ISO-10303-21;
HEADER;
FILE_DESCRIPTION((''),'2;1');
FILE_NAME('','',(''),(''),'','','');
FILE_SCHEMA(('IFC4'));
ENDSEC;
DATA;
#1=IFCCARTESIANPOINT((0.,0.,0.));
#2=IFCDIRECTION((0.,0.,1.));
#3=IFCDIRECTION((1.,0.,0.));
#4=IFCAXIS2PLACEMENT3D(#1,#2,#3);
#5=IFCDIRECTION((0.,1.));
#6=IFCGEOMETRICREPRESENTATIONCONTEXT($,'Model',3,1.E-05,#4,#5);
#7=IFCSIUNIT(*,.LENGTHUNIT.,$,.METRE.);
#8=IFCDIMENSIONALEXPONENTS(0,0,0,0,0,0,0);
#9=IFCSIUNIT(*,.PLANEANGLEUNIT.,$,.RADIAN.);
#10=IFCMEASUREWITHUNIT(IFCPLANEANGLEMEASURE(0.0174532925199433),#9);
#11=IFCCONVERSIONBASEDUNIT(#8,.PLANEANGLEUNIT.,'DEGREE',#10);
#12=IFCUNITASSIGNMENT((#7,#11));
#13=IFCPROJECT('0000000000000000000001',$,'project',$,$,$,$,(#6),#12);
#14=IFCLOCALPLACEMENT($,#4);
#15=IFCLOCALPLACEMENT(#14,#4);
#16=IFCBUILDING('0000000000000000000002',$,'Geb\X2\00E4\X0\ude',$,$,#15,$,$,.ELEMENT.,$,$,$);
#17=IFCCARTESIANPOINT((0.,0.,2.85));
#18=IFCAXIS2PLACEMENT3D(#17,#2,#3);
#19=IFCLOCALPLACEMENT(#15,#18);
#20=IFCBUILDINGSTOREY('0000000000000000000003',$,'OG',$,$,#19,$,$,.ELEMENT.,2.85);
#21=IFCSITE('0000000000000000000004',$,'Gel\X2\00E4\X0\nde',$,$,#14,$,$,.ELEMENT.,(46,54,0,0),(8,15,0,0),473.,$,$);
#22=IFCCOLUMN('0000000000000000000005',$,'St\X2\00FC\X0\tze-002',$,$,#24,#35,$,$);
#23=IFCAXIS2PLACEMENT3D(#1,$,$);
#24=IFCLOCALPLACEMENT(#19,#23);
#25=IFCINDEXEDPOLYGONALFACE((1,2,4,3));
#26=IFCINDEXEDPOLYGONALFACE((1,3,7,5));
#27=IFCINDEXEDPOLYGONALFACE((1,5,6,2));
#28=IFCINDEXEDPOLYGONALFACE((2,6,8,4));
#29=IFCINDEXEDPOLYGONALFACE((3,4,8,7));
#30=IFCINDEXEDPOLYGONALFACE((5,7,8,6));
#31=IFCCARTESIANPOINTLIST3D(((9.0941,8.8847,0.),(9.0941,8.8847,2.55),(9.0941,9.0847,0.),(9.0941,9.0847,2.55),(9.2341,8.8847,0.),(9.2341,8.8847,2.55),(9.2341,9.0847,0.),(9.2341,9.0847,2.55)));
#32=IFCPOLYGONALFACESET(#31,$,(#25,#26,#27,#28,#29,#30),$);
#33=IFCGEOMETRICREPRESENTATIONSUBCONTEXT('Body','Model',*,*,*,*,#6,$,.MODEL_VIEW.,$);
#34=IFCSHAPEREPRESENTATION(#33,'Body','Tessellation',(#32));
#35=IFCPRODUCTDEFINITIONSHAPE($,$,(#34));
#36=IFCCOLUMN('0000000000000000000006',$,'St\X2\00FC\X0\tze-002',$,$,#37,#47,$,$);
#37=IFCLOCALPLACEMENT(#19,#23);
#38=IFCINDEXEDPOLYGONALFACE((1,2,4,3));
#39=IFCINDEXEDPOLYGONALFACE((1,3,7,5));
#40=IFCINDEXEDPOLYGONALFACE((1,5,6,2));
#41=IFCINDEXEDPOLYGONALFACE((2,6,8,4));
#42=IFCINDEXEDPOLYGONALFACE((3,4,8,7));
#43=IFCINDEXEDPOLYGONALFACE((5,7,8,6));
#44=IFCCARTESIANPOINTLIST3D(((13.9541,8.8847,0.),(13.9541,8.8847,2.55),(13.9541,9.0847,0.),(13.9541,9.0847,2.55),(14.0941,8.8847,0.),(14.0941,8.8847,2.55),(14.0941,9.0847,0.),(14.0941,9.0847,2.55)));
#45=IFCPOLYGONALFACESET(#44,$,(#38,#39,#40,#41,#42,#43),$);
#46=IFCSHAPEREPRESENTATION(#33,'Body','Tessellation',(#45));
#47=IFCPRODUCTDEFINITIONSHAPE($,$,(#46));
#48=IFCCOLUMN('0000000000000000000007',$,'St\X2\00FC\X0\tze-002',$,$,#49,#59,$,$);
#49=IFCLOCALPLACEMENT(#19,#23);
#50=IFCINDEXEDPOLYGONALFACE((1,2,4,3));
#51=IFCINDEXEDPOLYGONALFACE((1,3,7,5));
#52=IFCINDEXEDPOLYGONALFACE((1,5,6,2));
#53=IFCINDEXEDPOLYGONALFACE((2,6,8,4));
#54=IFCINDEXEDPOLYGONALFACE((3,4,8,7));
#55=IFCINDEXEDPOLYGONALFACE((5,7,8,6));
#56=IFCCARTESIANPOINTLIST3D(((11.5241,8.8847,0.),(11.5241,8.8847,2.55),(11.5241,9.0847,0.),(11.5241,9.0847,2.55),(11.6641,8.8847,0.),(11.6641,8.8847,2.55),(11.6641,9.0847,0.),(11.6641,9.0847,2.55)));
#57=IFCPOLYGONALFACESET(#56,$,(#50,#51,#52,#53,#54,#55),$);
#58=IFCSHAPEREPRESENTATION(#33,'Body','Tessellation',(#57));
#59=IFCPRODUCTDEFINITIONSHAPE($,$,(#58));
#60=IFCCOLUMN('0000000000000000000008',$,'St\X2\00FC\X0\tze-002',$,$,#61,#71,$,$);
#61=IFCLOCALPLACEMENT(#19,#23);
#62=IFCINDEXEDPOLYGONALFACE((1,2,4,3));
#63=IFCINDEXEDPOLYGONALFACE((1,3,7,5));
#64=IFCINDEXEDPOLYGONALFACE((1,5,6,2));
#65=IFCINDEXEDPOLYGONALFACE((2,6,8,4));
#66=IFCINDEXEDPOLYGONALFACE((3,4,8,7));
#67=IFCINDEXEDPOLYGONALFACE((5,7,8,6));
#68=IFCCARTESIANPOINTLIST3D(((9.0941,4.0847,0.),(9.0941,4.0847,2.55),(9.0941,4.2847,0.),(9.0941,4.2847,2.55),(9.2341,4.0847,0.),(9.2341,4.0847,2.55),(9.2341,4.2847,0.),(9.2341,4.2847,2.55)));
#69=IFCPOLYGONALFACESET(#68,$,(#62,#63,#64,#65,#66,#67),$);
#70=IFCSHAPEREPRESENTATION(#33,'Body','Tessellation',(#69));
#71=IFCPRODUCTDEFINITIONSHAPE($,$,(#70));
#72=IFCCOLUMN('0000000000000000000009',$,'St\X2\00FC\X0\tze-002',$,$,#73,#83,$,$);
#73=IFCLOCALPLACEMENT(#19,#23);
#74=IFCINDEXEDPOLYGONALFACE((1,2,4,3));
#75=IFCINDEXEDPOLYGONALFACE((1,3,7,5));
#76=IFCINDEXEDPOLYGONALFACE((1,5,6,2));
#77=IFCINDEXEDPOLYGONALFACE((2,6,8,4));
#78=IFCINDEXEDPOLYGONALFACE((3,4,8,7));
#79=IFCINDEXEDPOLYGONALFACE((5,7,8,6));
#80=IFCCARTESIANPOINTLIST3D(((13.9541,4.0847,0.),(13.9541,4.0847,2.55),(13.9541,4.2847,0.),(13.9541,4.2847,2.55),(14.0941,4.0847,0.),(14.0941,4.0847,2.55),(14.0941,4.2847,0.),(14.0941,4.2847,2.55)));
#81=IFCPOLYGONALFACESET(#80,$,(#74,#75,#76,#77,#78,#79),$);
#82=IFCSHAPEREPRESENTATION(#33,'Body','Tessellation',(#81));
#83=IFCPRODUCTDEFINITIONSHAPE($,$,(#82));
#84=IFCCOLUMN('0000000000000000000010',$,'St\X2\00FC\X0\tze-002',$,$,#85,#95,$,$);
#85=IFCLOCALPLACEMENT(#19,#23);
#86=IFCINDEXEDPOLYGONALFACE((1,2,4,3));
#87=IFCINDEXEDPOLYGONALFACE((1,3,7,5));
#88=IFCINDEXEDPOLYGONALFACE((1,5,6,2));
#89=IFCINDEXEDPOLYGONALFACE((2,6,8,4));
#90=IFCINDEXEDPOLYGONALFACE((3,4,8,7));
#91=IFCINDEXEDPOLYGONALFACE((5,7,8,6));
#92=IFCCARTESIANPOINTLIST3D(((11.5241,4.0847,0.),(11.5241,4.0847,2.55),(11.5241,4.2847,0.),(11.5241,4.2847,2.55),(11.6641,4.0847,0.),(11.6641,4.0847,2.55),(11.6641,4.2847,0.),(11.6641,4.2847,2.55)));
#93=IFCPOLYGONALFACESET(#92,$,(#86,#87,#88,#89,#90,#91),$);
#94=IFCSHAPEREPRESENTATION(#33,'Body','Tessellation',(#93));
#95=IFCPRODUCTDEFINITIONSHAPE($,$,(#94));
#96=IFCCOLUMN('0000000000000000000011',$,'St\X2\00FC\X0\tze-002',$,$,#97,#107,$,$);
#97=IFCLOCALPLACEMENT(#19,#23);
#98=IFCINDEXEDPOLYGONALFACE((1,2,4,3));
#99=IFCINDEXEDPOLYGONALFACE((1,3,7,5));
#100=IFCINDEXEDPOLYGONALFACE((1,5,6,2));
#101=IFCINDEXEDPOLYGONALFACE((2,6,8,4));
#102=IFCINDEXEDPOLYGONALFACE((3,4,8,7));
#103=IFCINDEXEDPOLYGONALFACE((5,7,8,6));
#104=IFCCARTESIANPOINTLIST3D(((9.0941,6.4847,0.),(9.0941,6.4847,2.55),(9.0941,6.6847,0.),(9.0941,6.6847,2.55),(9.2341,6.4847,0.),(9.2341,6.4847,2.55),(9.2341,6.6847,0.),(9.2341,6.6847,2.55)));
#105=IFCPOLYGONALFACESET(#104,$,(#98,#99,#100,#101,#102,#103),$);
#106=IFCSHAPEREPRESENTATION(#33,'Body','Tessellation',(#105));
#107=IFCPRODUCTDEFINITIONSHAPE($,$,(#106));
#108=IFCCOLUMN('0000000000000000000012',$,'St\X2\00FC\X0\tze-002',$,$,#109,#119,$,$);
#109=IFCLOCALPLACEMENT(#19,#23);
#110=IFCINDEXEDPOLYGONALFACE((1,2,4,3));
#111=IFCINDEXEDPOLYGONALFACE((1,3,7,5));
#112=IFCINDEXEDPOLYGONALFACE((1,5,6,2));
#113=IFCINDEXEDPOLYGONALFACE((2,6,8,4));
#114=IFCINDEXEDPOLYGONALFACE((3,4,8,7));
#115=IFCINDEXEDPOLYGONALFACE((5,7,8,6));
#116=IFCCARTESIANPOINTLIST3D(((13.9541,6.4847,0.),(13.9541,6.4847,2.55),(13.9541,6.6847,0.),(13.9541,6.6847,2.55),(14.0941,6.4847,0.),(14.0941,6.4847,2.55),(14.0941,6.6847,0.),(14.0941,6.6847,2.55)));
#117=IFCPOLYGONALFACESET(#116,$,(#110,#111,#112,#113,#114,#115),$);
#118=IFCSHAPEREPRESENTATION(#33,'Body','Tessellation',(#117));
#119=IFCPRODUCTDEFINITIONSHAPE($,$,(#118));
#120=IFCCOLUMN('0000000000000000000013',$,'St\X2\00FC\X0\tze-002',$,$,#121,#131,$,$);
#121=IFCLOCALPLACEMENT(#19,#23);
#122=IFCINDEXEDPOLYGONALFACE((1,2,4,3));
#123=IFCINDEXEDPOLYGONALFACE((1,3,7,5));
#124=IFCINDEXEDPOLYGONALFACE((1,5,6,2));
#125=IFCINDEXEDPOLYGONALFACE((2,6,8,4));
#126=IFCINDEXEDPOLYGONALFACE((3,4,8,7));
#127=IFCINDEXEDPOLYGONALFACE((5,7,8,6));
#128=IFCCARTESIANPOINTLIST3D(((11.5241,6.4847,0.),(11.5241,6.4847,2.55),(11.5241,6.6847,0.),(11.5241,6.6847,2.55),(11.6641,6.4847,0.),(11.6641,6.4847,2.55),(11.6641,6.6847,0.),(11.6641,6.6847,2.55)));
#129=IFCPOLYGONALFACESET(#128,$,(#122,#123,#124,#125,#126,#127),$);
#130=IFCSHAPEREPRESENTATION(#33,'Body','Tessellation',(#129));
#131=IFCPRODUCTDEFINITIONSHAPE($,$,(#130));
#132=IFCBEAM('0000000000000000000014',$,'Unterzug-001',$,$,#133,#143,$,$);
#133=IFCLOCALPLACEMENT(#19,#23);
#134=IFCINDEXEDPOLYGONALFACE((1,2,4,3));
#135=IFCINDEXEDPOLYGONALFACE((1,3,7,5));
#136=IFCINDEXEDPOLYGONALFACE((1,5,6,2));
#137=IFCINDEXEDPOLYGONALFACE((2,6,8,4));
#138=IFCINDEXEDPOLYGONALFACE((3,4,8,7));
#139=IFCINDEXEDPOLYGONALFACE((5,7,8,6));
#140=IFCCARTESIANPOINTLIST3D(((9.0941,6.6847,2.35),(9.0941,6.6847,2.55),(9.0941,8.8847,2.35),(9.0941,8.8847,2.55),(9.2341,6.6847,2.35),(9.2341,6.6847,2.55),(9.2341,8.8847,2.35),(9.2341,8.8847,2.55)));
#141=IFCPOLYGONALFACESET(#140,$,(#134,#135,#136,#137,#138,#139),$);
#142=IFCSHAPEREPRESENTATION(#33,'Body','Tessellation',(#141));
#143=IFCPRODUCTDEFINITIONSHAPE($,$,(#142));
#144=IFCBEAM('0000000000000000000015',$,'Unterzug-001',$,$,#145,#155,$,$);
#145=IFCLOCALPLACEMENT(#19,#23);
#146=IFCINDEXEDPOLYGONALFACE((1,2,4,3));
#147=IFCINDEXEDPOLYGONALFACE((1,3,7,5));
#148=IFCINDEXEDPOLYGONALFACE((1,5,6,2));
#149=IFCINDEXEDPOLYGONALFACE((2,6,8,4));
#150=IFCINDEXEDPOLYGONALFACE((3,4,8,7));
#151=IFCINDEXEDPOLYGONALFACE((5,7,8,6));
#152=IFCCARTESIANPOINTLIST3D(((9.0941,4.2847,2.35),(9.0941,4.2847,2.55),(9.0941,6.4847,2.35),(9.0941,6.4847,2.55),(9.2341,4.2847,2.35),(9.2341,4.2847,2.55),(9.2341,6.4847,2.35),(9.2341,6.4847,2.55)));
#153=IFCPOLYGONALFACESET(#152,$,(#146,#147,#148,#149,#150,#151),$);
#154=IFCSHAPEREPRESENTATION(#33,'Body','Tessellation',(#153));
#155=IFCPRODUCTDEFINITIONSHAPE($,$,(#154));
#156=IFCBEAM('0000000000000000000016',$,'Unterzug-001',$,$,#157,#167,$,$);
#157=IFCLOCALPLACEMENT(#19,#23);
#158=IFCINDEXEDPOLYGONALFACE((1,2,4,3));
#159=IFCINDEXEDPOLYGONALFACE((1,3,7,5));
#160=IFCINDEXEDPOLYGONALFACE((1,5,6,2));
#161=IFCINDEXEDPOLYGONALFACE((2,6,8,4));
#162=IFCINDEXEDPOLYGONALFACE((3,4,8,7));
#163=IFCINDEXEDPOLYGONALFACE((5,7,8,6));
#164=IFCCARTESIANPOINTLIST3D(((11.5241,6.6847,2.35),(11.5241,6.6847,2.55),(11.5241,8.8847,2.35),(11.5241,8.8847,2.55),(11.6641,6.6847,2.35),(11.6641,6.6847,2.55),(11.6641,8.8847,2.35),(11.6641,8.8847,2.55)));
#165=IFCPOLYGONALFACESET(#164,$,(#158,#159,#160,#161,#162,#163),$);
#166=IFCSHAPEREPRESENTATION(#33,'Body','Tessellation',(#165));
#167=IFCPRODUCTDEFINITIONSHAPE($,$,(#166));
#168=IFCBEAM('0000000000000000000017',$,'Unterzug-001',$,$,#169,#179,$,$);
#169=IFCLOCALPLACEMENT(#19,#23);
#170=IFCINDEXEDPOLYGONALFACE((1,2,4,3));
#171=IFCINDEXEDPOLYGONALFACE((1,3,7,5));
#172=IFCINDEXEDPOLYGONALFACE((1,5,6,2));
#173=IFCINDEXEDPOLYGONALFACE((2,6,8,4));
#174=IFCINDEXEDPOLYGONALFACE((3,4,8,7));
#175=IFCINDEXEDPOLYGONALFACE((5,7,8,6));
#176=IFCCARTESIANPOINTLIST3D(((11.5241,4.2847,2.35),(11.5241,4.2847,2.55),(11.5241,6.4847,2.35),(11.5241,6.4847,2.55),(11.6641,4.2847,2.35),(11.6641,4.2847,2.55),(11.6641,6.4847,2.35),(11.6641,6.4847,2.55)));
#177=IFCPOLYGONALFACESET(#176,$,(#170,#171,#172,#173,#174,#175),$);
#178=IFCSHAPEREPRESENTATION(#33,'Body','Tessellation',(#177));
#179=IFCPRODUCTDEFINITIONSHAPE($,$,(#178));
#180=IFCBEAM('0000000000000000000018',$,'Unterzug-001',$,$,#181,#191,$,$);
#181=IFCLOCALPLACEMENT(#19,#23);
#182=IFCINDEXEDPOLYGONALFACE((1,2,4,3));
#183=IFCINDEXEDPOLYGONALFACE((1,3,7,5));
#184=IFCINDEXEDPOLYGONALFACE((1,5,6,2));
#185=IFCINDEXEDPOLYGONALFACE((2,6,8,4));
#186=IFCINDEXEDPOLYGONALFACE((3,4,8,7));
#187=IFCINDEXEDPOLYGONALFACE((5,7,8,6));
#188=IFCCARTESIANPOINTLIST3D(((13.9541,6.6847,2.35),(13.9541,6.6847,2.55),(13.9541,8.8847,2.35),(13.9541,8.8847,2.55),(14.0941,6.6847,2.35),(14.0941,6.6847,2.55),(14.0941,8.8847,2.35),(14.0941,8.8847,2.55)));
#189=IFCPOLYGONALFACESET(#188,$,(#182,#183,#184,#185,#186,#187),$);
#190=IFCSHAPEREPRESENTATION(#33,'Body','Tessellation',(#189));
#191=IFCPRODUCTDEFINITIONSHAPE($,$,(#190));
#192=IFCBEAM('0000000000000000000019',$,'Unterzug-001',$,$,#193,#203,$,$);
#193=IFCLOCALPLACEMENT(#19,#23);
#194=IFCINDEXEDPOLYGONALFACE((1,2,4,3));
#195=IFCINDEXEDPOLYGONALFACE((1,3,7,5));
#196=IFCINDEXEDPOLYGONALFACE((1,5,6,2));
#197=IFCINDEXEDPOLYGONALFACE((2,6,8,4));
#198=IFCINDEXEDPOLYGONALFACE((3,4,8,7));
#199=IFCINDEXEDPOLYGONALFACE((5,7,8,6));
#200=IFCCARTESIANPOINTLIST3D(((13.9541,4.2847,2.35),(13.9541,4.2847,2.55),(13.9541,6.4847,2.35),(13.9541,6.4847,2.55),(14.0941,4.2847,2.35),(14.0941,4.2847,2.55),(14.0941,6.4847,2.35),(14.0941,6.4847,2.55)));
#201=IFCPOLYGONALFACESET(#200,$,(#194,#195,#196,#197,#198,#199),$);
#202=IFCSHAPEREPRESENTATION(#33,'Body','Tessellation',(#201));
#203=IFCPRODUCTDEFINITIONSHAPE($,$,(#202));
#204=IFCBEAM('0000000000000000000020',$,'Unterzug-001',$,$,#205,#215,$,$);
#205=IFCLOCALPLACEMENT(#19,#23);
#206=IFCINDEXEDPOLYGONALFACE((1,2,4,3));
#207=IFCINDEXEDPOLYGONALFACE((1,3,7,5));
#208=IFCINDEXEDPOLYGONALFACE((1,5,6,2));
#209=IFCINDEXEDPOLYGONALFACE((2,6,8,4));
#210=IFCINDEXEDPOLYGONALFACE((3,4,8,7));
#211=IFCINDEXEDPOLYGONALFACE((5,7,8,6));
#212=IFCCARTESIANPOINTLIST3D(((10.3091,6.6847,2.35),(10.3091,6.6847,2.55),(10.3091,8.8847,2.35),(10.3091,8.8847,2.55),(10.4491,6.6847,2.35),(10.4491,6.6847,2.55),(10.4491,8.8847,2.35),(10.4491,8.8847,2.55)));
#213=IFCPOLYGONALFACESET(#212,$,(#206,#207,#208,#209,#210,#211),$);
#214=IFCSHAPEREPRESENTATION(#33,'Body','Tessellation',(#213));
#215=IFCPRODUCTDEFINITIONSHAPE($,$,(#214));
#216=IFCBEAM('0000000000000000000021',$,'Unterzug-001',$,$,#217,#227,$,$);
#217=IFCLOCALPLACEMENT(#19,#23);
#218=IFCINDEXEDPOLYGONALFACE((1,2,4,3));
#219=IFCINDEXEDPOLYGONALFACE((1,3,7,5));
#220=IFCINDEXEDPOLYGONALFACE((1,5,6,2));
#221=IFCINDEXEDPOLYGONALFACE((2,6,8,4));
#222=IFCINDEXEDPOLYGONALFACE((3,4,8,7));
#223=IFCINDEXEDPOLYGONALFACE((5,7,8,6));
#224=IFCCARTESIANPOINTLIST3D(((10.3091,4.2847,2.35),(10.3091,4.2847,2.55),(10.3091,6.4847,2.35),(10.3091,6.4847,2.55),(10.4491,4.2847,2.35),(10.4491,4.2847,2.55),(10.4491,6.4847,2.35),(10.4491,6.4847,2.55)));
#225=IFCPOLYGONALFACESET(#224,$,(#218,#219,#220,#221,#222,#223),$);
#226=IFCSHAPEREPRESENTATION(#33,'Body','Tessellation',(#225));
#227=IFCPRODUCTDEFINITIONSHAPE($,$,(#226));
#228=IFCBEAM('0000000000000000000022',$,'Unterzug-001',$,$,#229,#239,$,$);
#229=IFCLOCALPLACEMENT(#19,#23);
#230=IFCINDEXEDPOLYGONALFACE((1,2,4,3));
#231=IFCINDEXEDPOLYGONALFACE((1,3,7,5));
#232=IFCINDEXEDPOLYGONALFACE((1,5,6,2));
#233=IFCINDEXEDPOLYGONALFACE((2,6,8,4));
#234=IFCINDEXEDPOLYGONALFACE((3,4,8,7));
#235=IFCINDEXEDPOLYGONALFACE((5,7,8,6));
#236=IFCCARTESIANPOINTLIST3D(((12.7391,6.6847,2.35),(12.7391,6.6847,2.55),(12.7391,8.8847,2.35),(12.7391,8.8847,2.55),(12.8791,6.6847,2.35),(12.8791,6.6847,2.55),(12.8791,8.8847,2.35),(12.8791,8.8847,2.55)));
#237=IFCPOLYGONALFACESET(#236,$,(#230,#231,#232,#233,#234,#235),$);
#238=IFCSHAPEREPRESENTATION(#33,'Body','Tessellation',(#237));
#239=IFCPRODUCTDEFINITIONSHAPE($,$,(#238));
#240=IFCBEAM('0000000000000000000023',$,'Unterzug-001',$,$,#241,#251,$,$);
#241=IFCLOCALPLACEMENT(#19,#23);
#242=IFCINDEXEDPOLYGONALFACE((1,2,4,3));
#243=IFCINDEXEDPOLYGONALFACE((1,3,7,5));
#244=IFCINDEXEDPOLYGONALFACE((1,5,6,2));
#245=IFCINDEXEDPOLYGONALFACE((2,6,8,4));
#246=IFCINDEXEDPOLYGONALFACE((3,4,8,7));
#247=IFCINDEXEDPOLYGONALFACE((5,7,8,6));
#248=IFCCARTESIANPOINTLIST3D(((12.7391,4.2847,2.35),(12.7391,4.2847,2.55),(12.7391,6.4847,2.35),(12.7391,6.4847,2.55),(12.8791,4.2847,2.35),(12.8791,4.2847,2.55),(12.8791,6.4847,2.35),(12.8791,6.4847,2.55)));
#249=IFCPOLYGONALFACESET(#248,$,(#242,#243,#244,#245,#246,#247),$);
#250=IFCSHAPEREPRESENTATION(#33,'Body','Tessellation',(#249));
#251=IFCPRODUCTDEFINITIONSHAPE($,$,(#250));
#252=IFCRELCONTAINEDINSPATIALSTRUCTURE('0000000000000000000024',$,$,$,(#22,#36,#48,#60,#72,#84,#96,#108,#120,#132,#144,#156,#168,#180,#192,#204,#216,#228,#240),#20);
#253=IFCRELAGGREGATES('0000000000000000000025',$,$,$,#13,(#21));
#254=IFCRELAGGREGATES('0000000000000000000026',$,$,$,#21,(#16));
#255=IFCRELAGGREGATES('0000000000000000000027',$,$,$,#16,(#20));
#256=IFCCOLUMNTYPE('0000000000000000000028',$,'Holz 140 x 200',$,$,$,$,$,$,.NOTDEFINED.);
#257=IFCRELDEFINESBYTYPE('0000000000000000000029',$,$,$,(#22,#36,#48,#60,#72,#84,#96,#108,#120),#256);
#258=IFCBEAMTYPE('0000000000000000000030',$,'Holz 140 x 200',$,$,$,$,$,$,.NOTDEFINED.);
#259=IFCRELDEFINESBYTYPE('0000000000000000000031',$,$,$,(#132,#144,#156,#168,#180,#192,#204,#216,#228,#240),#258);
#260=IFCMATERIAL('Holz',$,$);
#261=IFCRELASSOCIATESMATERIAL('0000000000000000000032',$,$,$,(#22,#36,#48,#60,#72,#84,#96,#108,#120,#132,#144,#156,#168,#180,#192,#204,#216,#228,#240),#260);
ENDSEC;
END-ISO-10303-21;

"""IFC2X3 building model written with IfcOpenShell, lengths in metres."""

from ifc_helpers import new_model, entity, si_unit, converted_unit, direction, frame, frame_2d, origin_with_axes, origin_2d_with_axis, place, context, subcontext, project, spatial, rectangle, extrude, material, type_object, element, save


model = new_model("IFC2X3")

# Units and contexts
model_context = context("Model", 3, precision=1e-05, world=origin_with_axes(), true_north=direction((0.0, 1.0)))
body_context = subcontext(model_context, "Body", "Model", "MODEL_VIEW")
ifc_project = project(units=[si_unit("LENGTHUNIT", "METRE"), converted_unit("PLANEANGLEUNIT", "DEGREE", entity("IfcPlaneAngleMeasure", 0.0174532925199433), si_unit("PLANEANGLEUNIT", "RADIAN"), dimensions=[0, 0, 0, 0, 0, 0, 0])], contexts=[model_context])

# Site, building, storey
site_placement = place(None, origin_with_axes())
site = spatial("IfcSite", under=ifc_project, at=site_placement, Name="Gelände", CompositionType="ELEMENT", RefLatitude=(46, 54, 0, 0), RefLongitude=(8, 15, 0, 0), RefElevation=473.0)
building_placement = place(site_placement, origin_with_axes())
building = spatial("IfcBuilding", under=site, at=building_placement, Name="Gebäude", CompositionType="ELEMENT")
storey_placement = place(building_placement, frame((0.0, 0.0, 2.85), z_axis=(0.0, 0.0, 1.0), x_axis=(1.0, 0.0, 0.0)))
storey = spatial("IfcBuildingStorey", under=building, at=storey_placement, Name="OG", CompositionType="ELEMENT", Elevation=2.85)

# Columns
ifc_material_1 = material(Name="Holz")
column_type = type_object("IfcColumnType", Name="Holz 140 x 200", PredefinedType="NOTDEFINED")
for number, where, z_axis, x_axis, name in (
    (1, (9.1641, 8.9847, 0.0), (0.0, 0.0, 1.0), (1.0, 0.0, 0.0), "Stütze-002"),
    (2, (14.0241, 8.9847, 0.0), (0.0, 0.0, 1.0), (1.0, 0.0, 0.0), "Stütze-002"),
    (3, (11.5941, 8.9847, 0.0), (0.0, 0.0, 1.0), (1.0, 0.0, 0.0), "Stütze-002"),
    (4, (9.1641, 4.1847, 0.0), (0.0, 0.0, 1.0), (1.0, 0.0, 0.0), "Stütze-002"),
    (5, (14.0241, 4.1847, 0.0), (0.0, 0.0, 1.0), (1.0, 0.0, 0.0), "Stütze-002"),
    (6, (11.5941, 4.1847, 0.0), (0.0, 0.0, 1.0), (1.0, 0.0, 0.0), "Stütze-002"),
    (7, (9.1641, 6.5847, 0.0), (0.0, 0.0, 1.0), (1.0, 0.0, 0.0), "Stütze-002"),
    (8, (14.0241, 6.5847, 0.0), (0.0, 0.0, 1.0), (1.0, 0.0, 0.0), "Stütze-002"),
    (9, (11.5941, 6.5847, 0.0), (0.0, 0.0, 1.0), (1.0, 0.0, 0.0), "Stütze-002"),
):
    element("IfcColumn", number, at=place(storey_placement, frame(where, z_axis=z_axis, x_axis=x_axis)), inside=storey, type_object=column_type, material=ifc_material_1, Name=name, context=body_context, shape_type="SweptSolid", body=[
        extrude(rectangle(XDim=0.14, YDim=0.2, at=origin_2d_with_axis()), origin_with_axes(), (0.0, 0.0, 1.0), 2.55),
    ])

# Beams
beam_type = type_object("IfcBeamType", Name="Holz 140 x 200", PredefinedType="NOTDEFINED")
for number, where, z_axis, x_axis, name in (
    (10, (9.1641, 6.6847, 2.55), (0.0, 0.0, 1.0), (1.0, 0.0, 0.0), "Unterzug-001"),
    (11, (9.1641, 4.2847, 2.55), (0.0, 0.0, 1.0), (1.0, 0.0, 0.0), "Unterzug-001"),
    (12, (11.5941, 6.6847, 2.55), (0.0, 0.0, 1.0), (1.0, 0.0, 0.0), "Unterzug-001"),
    (13, (11.5941, 4.2847, 2.55), (0.0, 0.0, 1.0), (1.0, 0.0, 0.0), "Unterzug-001"),
    (14, (14.0241, 6.6847, 2.55), (0.0, 0.0, 1.0), (1.0, 0.0, 0.0), "Unterzug-001"),
    (15, (14.0241, 4.2847, 2.55), (0.0, 0.0, 1.0), (1.0, 0.0, 0.0), "Unterzug-001"),
    (16, (10.3791, 6.6847, 2.55), (0.0, 0.0, 1.0), (1.0, 0.0, 0.0), "Unterzug-001"),
    (17, (10.3791, 4.2847, 2.55), (0.0, 0.0, 1.0), (1.0, 0.0, 0.0), "Unterzug-001"),
    (18, (12.8091, 6.6847, 2.55), (0.0, 0.0, 1.0), (1.0, 0.0, 0.0), "Unterzug-001"),
    (19, (12.8091, 4.2847, 2.55), (0.0, 0.0, 1.0), (1.0, 0.0, 0.0), "Unterzug-001"),
):
    element("IfcBeam", number, at=place(storey_placement, frame(where, z_axis=z_axis, x_axis=x_axis)), inside=storey, type_object=beam_type, material=ifc_material_1, Name=name, context=body_context, shape_type="SweptSolid", body=[
        extrude(rectangle(XDim=0.2, YDim=0.14, at=frame_2d((-0.1, 0.0), x_axis=(1.0, 0.0))), frame((0.0, 0.0, 0.0), z_axis=(0.0, 1.0, 0.0), x_axis=(0.0, 0.0, 1.0)), (0.0, 0.0, 1.0), 2.2),
    ])

save(model, "model.ifc")
